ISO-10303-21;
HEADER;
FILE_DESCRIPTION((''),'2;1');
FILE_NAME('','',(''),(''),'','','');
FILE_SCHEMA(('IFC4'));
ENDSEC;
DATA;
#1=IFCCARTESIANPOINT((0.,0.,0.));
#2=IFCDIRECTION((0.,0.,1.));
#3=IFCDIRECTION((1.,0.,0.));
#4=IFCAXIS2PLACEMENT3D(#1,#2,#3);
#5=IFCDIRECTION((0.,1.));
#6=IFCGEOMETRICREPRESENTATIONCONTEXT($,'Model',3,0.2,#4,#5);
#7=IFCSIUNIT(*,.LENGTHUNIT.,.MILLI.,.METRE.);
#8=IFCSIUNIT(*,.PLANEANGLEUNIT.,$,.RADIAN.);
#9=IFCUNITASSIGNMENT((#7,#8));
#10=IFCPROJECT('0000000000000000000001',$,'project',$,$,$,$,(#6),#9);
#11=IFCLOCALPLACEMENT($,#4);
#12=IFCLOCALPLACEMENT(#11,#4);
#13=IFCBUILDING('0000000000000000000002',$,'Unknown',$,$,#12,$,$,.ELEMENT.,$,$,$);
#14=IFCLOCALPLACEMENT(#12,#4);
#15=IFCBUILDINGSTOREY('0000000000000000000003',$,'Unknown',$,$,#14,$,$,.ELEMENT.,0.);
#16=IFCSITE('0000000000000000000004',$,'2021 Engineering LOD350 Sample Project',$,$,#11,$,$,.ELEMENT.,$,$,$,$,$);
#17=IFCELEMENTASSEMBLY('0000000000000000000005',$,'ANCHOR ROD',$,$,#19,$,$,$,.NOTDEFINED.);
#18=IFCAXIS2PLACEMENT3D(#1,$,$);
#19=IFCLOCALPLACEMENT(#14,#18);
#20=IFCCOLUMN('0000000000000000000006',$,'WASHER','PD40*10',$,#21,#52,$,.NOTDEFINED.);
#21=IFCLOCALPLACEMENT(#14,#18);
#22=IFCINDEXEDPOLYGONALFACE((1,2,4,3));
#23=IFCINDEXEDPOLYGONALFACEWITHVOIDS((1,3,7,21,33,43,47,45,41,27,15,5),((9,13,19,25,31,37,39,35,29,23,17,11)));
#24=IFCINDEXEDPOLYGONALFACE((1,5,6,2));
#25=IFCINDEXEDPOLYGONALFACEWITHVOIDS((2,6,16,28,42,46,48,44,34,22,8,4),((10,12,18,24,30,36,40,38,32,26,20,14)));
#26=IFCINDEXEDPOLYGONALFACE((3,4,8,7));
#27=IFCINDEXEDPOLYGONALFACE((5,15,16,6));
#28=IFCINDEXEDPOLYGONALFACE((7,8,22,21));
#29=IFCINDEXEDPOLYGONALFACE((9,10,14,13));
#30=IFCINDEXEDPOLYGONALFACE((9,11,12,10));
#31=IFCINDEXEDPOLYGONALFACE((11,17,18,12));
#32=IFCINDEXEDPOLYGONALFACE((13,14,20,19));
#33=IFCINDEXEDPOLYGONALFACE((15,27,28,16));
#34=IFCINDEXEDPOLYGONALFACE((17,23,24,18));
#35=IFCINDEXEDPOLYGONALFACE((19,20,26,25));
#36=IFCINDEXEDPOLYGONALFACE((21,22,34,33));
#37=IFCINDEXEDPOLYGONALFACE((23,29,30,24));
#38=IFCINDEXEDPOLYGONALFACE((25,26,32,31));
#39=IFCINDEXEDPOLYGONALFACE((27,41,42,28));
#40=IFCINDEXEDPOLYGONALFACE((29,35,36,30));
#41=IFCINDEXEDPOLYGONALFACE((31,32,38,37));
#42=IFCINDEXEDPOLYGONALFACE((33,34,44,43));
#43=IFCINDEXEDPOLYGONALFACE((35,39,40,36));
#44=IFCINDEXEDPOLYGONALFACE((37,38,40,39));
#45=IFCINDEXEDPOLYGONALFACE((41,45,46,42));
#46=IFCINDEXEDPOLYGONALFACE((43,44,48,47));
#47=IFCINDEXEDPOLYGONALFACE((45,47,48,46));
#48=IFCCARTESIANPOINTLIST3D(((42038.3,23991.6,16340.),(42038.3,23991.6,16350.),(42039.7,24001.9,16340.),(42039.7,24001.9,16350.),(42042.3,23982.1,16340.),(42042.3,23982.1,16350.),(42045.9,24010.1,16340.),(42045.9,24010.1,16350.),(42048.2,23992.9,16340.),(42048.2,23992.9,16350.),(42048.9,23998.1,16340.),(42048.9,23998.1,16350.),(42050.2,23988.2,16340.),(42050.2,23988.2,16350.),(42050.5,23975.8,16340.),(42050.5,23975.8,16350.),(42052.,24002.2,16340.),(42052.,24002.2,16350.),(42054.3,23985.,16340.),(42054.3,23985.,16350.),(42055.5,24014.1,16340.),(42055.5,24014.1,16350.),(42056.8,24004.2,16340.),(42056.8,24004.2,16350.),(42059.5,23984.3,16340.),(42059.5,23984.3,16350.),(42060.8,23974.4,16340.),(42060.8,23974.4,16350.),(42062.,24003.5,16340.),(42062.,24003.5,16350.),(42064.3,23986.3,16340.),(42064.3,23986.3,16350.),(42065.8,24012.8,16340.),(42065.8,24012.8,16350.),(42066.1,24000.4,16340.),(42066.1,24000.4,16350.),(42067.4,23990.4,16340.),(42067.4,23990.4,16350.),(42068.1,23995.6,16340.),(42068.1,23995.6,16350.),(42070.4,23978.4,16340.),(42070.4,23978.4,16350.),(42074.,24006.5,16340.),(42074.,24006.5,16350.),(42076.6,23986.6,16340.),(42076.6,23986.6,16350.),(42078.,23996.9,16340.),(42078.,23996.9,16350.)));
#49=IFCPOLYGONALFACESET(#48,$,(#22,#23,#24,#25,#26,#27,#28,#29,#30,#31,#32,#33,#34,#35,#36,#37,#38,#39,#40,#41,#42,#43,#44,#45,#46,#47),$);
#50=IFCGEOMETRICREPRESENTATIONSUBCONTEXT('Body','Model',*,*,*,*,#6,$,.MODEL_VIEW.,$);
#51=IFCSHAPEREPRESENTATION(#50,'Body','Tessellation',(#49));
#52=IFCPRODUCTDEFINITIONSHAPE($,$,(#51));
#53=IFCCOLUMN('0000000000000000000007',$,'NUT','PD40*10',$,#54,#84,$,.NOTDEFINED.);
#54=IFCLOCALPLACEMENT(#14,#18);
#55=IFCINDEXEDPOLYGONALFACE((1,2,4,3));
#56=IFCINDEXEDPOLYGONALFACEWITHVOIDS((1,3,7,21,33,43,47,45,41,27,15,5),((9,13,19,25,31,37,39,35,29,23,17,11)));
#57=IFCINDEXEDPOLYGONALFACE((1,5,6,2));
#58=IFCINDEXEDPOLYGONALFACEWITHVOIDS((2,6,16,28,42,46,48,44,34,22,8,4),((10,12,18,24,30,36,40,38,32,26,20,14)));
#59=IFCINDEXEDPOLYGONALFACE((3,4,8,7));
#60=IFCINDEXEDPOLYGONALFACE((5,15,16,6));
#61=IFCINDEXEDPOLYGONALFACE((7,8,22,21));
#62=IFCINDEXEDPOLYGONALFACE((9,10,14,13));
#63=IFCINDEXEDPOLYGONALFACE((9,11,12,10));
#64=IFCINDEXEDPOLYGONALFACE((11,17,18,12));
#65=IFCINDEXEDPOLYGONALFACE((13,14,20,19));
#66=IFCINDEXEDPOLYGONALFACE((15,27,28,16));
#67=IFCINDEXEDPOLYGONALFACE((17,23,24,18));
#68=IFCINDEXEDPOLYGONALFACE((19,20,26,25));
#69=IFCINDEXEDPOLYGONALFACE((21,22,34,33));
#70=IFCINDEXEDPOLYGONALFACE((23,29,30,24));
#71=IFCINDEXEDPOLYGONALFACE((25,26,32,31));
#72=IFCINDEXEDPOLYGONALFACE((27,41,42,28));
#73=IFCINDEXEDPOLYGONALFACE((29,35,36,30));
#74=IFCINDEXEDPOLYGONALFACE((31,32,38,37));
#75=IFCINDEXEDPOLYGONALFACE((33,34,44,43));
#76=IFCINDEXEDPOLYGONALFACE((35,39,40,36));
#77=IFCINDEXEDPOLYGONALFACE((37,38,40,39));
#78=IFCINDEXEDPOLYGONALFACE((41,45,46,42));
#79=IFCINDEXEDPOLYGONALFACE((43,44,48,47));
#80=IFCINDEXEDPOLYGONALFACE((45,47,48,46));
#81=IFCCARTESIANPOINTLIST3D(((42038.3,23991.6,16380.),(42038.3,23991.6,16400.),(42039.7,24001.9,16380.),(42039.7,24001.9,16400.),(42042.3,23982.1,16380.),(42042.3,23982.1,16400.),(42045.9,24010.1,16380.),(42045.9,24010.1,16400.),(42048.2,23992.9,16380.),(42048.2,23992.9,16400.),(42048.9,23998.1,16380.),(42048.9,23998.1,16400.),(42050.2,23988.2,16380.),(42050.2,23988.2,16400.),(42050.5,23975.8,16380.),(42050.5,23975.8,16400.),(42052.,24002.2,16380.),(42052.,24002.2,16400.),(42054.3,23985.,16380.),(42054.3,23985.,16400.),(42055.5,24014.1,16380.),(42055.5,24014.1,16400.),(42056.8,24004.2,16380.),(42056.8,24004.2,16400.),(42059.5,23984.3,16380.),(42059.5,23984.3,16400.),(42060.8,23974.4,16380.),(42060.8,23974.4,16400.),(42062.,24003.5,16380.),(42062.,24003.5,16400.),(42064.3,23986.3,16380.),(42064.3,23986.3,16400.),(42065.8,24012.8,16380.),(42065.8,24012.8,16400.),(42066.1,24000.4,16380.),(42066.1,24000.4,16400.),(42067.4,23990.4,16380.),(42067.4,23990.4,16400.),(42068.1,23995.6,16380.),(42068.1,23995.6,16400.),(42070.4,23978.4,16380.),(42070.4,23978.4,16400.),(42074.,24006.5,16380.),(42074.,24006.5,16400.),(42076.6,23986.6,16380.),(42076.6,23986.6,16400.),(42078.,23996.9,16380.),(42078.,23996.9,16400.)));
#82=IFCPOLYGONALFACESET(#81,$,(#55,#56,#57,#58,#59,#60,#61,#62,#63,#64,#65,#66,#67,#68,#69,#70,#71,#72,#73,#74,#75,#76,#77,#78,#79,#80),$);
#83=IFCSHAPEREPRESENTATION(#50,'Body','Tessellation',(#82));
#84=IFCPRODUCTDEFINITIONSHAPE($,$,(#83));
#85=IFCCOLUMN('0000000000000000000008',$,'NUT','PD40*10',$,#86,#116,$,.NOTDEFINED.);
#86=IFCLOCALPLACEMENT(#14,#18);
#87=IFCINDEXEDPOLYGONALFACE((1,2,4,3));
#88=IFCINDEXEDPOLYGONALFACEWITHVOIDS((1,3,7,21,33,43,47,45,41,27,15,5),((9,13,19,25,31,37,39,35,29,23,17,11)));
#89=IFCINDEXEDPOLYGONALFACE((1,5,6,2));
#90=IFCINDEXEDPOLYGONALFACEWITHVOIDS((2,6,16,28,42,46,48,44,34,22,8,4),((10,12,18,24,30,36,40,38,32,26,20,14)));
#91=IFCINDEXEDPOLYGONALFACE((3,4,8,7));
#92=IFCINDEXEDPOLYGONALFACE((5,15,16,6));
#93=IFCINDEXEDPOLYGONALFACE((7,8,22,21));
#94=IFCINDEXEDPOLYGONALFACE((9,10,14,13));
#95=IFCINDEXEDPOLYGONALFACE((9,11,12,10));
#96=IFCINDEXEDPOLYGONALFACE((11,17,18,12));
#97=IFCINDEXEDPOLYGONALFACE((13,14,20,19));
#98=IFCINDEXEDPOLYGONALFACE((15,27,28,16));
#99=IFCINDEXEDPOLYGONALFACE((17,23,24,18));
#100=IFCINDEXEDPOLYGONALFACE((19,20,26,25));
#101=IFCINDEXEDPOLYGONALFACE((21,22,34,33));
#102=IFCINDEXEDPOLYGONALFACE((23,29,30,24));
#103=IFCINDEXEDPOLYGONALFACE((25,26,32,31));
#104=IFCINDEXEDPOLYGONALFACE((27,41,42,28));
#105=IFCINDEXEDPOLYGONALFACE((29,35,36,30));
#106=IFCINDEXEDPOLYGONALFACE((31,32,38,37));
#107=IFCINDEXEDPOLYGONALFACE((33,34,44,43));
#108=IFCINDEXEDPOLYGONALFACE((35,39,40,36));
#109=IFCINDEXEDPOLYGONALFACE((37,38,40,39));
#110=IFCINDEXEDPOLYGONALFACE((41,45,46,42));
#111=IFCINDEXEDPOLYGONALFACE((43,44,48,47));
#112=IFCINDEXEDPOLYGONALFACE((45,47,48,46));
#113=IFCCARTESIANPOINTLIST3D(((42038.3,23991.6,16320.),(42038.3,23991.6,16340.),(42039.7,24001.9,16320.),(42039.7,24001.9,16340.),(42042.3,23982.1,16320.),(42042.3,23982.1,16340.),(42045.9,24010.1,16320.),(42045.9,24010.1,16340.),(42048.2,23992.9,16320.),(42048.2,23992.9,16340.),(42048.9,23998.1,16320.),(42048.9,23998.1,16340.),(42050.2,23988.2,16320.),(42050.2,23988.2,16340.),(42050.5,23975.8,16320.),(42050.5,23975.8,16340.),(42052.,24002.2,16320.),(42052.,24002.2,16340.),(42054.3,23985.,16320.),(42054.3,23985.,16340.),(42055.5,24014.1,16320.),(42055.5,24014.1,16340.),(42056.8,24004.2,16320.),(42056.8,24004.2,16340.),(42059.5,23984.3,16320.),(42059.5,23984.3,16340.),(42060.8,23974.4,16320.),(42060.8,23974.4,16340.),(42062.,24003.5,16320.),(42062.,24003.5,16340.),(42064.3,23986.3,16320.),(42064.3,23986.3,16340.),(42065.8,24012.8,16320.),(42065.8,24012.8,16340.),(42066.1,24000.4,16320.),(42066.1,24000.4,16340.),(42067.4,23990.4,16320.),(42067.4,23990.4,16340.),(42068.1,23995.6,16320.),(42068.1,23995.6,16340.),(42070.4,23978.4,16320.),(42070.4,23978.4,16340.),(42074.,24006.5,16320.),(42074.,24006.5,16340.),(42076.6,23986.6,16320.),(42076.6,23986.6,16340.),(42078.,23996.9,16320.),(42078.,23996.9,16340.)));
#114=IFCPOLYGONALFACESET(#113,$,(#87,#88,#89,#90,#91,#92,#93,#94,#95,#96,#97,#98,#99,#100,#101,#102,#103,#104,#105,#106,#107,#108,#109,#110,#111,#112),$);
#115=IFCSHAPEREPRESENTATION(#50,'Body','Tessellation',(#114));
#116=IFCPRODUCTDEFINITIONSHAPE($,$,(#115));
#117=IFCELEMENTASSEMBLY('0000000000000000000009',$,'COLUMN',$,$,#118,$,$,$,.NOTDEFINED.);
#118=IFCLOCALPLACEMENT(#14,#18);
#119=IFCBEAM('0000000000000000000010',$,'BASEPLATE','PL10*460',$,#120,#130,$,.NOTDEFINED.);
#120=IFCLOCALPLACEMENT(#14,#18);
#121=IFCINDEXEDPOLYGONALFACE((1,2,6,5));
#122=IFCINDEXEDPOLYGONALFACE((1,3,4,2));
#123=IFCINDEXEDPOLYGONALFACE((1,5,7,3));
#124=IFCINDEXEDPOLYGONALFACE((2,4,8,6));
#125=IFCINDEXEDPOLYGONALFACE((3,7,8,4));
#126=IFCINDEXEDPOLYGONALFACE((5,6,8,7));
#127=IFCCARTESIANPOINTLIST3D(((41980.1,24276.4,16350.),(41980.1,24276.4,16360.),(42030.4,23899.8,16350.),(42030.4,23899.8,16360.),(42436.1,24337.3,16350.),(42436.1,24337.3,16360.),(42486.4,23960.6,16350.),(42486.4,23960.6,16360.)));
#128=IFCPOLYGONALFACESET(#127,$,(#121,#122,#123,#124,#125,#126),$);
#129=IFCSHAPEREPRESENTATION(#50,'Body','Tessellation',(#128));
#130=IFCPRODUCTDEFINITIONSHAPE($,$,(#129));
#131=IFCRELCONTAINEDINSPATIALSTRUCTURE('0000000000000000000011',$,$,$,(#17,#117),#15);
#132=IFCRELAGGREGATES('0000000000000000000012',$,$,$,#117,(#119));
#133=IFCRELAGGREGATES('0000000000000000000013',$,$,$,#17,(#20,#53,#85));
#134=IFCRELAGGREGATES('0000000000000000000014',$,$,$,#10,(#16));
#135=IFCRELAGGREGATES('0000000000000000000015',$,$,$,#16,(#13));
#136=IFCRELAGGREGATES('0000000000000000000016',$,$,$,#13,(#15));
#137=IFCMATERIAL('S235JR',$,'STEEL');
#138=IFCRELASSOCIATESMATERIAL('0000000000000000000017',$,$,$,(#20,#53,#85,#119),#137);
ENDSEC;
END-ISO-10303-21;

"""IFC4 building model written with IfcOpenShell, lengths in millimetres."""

from ifc_helpers import new_model, si_unit, direction, frame, origin_with_axes, place, context, subcontext, project, spatial, line, indexed_curve, outline, extrude, material, element, aggregate, save


model = new_model("IFC4")

# Units and contexts
model_context = context("Model", 3, precision=0.2, world=origin_with_axes(), true_north=direction((0.0, 1.0)))
body_context = subcontext(model_context, "Body", "Model", "MODEL_VIEW")
ifc_project = project(units=[si_unit("LENGTHUNIT", "METRE", prefix="MILLI"), si_unit("PLANEANGLEUNIT", "RADIAN")], contexts=[model_context])

# Site, building, storey
site_placement = place(None, origin_with_axes())
site = spatial("IfcSite", under=ifc_project, at=site_placement, Name="2021 Engineering LOD350 Sample Project", CompositionType="ELEMENT")
building_placement = place(site_placement, origin_with_axes())
building = spatial("IfcBuilding", under=site, at=building_placement, Name="Unknown", CompositionType="ELEMENT")
storey_placement = place(building_placement, origin_with_axes())
storey = spatial("IfcBuildingStorey", under=building, at=storey_placement, Name="Unknown", CompositionType="ELEMENT", Elevation=0.0)

# Element assembly, columns
assembly_1_placement = place(storey_placement, frame((42408.4, 24242.8, 16410.0), z_axis=(0.991216, 0.132256, 0.0), x_axis=(0.0, 0.0, -1.0)))
assembly_1 = element("IfcElementAssembly", 1, at=assembly_1_placement, inside=storey, Name="ANCHOR ROD", PredefinedType="NOTDEFINED")
ifc_material_1 = material(Name="S235JR", Category="STEEL")
column_1_placement = place(assembly_1_placement, frame((60.0, -200.0, -380.0), z_axis=(0.0, 0.0, -1.0), x_axis=(1.0, 0.0, 0.0)))
column_1 = element("IfcColumn", 2, at=column_1_placement, material=ifc_material_1, Name="WASHER", Description="PD40*10", PredefinedType="NOTDEFINED", context=body_context, shape_type="SolidModel", body=[
    extrude(outline(indexed_curve([(20.0, 0.0), (17.3, 10.0), (10.0, 17.3), (0.0, 20.0), (-10.0, 17.3), (-17.3, 10.0), (-20.0, 0.0), (-17.3, -10.0), (-10.0, -17.3), (0.0, -20.0), (10.0, -17.3), (17.3, -10.0)], segments=[line(1, 2, 3, 4, 5, 6, 7, 8, 9, 10, 11, 12, 1)]), holes=[indexed_curve([(10.0, 0.0), (8.7, -5.0), (5.0, -8.7), (0.0, -10.0), (-5.0, -8.7), (-8.7, -5.0), (-10.0, 0.0), (-8.7, 5.0), (-5.0, 8.7), (0.0, 10.0), (5.0, 8.7), (8.7, 5.0)], segments=[line(1, 2, 3, 4, 5, 6, 7, 8, 9, 10, 11, 12, 1)])]), frame((0.0, 0.0, 0.0), z_axis=(-1.0, 0.0, 0.0), x_axis=(0.0, 0.0, 1.0)), (0.0, 0.0, -1.0), 10.0),
])
column_2_placement = place(assembly_1_placement, frame((10.0, -200.0, -380.0), z_axis=(0.0, 0.0, -1.0), x_axis=(1.0, 0.0, 0.0)))
column_2 = element("IfcColumn", 3, at=column_2_placement, material=ifc_material_1, Name="NUT", Description="PD40*10", PredefinedType="NOTDEFINED", context=body_context, shape_type="SolidModel", body=[
    extrude(outline(indexed_curve([(20.0, 0.0), (17.3, 10.0), (10.0, 17.3), (0.0, 20.0), (-10.0, 17.3), (-17.3, 10.0), (-20.0, 0.0), (-17.3, -10.0), (-10.0, -17.3), (0.0, -20.0), (10.0, -17.3), (17.3, -10.0)], segments=[line(1, 2, 3, 4, 5, 6, 7, 8, 9, 10, 11, 12, 1)]), holes=[indexed_curve([(10.0, 0.0), (8.7, -5.0), (5.0, -8.7), (0.0, -10.0), (-5.0, -8.7), (-8.7, -5.0), (-10.0, 0.0), (-8.7, 5.0), (-5.0, 8.7), (0.0, 10.0), (5.0, 8.7), (8.7, 5.0)], segments=[line(1, 2, 3, 4, 5, 6, 7, 8, 9, 10, 11, 12, 1)])]), frame((0.0, 0.0, 0.0), z_axis=(-1.0, 0.0, 0.0), x_axis=(0.0, 0.0, 1.0)), (0.0, 0.0, -1.0), 20.0),
])
column_3_placement = place(assembly_1_placement, frame((70.0, -200.0, -380.0), z_axis=(0.0, 0.0, -1.0), x_axis=(1.0, 0.0, 0.0)))
column_3 = element("IfcColumn", 4, at=column_3_placement, material=ifc_material_1, Name="NUT", Description="PD40*10", PredefinedType="NOTDEFINED", context=body_context, shape_type="SolidModel", body=[
    extrude(outline(indexed_curve([(20.0, 0.0), (17.3, 10.0), (10.0, 17.3), (0.0, 20.0), (-10.0, 17.3), (-17.3, 10.0), (-20.0, 0.0), (-17.3, -10.0), (-10.0, -17.3), (0.0, -20.0), (10.0, -17.3), (17.3, -10.0)], segments=[line(1, 2, 3, 4, 5, 6, 7, 8, 9, 10, 11, 12, 1)]), holes=[indexed_curve([(10.0, 0.0), (8.7, -5.0), (5.0, -8.7), (0.0, -10.0), (-5.0, -8.7), (-8.7, -5.0), (-10.0, 0.0), (-8.7, 5.0), (-5.0, 8.7), (0.0, 10.0), (5.0, 8.7), (8.7, 5.0)], segments=[line(1, 2, 3, 4, 5, 6, 7, 8, 9, 10, 11, 12, 1)])]), frame((0.0, 0.0, 0.0), z_axis=(-1.0, 0.0, 0.0), x_axis=(0.0, 0.0, 1.0)), (0.0, 0.0, -1.0), 20.0),
])

# Element assembly, beam
assembly_2_placement = place(storey_placement, frame((42233.3, 24118.5, 16500.0), z_axis=(-0.991216, -0.132256, 0.0), x_axis=(0.0, 0.0, 1.0)))
assembly_2 = element("IfcElementAssembly", 5, at=assembly_2_placement, inside=storey, Name="COLUMN", PredefinedType="NOTDEFINED")
beam_placement = place(assembly_2_placement, frame((-145.0, -190.0, 0.0), z_axis=(1.0, 0.0, 0.0), x_axis=(0.0, 1.0, 0.0)))
beam = element("IfcBeam", 6, at=beam_placement, material=ifc_material_1, Name="BASEPLATE", Description="PL10*460", PredefinedType="NOTDEFINED", context=body_context, shape_type="SolidModel", body=[
    extrude(outline(indexed_curve([(-5.0, -230.0), (5.0, -230.0), (5.0, 230.0), (-5.0, 230.0)], segments=[line(1, 2, 3, 4, 1)])), frame((0.0, 0.0, 0.0), z_axis=(-1.0, 0.0, 0.0), x_axis=(0.0, 0.0, 1.0)), (0.0, 0.0, -1.0), 380.0),
])

aggregate(assembly_2, [beam])
aggregate(assembly_1, [column_1, column_2, column_3])

save(model, "model.ifc")
